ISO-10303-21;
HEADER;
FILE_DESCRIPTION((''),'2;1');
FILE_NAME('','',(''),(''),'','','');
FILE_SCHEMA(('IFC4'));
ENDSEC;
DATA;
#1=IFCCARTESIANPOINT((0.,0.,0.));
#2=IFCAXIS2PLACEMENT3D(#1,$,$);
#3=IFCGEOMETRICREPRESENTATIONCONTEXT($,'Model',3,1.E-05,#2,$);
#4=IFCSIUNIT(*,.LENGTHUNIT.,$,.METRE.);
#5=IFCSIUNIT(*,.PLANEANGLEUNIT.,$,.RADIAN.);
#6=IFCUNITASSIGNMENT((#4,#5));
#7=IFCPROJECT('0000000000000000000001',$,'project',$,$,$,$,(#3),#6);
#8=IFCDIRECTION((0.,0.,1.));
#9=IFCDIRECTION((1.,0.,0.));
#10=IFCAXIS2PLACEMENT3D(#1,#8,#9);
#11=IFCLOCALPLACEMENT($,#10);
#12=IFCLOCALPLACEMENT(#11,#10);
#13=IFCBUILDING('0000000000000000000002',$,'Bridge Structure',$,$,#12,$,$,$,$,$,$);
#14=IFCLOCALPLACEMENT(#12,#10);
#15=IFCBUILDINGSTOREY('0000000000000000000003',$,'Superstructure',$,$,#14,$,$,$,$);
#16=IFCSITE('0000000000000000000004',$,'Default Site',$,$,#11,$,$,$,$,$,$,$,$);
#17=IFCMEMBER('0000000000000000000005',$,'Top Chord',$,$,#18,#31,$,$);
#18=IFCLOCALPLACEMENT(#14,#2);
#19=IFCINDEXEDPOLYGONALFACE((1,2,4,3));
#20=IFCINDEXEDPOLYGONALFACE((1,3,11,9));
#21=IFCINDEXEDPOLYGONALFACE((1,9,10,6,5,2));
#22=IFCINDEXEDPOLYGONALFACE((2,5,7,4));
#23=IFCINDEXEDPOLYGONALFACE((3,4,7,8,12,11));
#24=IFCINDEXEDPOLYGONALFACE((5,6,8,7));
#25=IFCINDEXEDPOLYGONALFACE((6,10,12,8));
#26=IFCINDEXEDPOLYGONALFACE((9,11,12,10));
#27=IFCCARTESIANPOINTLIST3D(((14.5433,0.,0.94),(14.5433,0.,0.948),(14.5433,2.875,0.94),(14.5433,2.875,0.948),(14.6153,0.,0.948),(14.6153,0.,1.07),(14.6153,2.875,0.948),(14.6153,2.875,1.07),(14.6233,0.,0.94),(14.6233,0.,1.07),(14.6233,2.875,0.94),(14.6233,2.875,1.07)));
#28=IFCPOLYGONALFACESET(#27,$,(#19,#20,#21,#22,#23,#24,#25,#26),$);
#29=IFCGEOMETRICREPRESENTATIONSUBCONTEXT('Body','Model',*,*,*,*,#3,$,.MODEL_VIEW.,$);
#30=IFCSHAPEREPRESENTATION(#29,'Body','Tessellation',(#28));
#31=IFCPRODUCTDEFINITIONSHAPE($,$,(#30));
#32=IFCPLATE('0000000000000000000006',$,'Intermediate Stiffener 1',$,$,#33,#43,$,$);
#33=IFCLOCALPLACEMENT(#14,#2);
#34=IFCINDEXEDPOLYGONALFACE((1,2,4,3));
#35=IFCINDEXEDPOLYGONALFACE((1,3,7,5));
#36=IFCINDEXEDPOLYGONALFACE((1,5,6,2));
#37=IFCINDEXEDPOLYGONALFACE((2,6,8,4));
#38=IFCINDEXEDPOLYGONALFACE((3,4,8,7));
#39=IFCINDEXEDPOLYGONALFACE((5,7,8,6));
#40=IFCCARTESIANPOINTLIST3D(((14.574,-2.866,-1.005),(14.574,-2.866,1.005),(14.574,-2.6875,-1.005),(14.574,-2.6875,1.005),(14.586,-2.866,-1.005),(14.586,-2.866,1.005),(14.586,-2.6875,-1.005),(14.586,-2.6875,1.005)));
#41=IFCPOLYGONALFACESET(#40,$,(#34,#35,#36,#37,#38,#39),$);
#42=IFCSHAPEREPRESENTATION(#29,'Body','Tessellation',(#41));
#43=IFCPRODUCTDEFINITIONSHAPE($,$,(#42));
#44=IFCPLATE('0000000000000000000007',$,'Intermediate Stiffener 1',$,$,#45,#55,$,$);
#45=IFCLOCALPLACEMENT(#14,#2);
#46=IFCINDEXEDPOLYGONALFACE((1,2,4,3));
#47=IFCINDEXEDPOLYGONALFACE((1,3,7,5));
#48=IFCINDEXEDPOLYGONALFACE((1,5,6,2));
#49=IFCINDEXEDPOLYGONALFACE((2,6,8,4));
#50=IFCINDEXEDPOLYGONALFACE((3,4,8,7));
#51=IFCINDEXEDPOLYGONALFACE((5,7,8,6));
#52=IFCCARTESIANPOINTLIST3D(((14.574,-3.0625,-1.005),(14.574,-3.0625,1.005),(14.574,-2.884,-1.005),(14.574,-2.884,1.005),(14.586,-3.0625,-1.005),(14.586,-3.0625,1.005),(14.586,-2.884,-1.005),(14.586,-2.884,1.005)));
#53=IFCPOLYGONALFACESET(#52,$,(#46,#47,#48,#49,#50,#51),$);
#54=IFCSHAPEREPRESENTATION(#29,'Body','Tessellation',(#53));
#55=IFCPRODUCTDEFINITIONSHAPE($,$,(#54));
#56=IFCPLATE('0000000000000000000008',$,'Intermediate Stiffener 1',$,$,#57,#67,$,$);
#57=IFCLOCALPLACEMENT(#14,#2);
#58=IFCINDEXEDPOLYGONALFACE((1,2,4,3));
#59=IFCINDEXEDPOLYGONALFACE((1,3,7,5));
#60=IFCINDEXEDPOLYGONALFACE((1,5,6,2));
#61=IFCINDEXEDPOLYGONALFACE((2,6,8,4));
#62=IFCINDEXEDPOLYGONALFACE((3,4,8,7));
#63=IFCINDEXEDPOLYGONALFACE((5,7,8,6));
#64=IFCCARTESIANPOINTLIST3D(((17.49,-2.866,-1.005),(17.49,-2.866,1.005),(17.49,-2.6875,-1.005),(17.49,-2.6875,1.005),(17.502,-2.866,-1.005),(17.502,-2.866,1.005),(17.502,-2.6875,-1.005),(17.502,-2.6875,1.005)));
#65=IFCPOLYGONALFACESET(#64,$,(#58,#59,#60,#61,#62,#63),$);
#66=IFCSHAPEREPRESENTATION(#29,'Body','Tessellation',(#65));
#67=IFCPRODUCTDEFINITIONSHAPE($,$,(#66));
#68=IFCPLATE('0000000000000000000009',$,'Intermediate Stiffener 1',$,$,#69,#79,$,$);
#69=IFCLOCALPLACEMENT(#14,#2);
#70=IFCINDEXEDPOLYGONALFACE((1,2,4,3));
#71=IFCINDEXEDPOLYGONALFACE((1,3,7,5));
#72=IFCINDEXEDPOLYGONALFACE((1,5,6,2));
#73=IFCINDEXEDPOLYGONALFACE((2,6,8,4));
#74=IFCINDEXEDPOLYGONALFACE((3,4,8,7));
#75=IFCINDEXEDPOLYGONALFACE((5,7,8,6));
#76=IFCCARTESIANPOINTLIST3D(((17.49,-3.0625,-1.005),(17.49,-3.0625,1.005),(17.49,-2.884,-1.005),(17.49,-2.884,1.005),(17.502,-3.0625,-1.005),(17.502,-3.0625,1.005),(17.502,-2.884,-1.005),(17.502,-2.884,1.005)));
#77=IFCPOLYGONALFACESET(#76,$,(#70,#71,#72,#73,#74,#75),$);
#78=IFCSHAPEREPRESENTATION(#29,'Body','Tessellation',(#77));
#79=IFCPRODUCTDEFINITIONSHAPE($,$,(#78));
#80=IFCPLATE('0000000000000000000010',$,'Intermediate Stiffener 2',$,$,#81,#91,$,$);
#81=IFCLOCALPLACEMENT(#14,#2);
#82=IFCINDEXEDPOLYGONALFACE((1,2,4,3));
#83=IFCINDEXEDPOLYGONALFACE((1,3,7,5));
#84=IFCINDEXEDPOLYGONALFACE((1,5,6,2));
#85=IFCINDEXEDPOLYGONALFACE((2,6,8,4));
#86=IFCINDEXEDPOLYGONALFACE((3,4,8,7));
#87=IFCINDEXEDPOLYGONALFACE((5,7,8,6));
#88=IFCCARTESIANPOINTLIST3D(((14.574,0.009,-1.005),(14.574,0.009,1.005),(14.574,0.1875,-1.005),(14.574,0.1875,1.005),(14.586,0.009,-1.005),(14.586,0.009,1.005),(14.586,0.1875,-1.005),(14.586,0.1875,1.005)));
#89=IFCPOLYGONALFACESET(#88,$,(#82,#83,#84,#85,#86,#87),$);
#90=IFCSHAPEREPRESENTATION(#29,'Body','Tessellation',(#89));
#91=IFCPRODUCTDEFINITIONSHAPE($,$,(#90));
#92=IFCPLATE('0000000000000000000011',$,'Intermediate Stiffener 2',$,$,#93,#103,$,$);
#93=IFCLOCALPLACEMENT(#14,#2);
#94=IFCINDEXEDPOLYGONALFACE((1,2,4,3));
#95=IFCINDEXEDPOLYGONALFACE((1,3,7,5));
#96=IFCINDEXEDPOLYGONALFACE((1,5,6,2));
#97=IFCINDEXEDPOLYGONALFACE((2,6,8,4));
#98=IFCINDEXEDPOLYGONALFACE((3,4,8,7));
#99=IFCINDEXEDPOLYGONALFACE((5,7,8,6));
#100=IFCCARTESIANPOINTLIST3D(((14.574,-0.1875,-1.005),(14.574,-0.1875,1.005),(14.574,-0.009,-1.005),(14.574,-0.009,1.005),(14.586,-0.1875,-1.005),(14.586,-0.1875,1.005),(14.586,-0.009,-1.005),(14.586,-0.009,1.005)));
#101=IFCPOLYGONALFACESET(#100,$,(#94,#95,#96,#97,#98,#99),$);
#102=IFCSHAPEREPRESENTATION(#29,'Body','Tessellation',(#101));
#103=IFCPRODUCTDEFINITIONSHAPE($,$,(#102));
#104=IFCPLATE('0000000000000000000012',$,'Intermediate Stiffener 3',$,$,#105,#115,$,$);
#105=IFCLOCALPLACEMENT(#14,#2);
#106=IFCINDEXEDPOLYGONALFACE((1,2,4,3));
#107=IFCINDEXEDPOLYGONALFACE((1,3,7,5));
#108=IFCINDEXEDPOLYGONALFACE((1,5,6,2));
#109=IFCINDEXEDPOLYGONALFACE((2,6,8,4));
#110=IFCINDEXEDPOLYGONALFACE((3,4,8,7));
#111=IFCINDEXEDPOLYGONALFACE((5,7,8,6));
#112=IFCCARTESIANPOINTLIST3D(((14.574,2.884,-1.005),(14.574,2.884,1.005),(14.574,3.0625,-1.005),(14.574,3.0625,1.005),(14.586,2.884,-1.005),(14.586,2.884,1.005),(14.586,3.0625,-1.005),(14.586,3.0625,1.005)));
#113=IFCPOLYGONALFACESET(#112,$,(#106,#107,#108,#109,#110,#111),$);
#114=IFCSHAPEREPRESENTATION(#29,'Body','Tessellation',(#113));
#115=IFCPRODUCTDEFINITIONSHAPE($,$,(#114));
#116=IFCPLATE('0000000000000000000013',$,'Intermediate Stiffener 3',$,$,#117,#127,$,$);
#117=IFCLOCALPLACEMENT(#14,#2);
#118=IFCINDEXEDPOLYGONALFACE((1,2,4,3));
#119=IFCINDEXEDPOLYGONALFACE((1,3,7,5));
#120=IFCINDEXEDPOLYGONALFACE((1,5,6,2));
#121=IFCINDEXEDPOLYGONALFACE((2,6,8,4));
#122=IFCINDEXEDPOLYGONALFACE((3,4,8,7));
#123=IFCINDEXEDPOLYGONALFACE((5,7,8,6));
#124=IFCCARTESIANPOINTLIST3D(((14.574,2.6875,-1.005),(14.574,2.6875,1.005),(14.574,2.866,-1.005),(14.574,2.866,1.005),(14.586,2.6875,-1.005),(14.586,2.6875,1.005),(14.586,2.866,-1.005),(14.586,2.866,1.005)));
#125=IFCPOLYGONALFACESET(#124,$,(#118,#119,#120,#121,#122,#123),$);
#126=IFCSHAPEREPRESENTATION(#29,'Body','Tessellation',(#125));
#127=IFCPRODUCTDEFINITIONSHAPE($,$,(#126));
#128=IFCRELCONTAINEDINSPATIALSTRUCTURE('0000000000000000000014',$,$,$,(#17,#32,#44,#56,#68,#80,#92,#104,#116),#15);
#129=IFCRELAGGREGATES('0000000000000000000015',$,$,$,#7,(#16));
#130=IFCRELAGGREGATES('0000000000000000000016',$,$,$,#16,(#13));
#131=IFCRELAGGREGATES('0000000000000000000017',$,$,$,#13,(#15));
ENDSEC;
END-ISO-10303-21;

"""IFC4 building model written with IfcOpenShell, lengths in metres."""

from ifc_helpers import new_model, si_unit, frame, origin, origin_with_axes, origin_2d_with_axis, place, context, subcontext, project, spatial, rectangle, l_section, extrude, element, save


model = new_model("IFC4")

# Units and contexts
model_context = context("Model", 3, precision=1e-05, world=origin())
body_context = subcontext(model_context, "Body", "Model", "MODEL_VIEW")
ifc_project = project(units=[si_unit("LENGTHUNIT", "METRE"), si_unit("PLANEANGLEUNIT", "RADIAN")], contexts=[model_context])

# Site, building, storey
site_placement = place(None, origin_with_axes())
site = spatial("IfcSite", under=ifc_project, at=site_placement, Name="Default Site")
building_placement = place(site_placement, origin_with_axes())
building = spatial("IfcBuilding", under=site, at=building_placement, Name="Bridge Structure")
storey_placement = place(building_placement, origin_with_axes())
storey = spatial("IfcBuildingStorey", under=building, at=storey_placement, Name="Superstructure")

# Member
for number, where, z_axis, x_axis, name in (
    (1, (14.5833, 0.0, 1.005), (0.0, 1.0, 0.0), (-1.0, 0.0, 0.0), "Top Chord"),
):
    element("IfcMember", number, at=place(storey_placement, frame(where, z_axis=z_axis, x_axis=x_axis)), inside=storey, Name=name, context=body_context, shape_type="SweptSolid", body=[
        extrude(l_section(Depth=0.13, Width=0.08, Thickness=0.008, at=origin_2d_with_axis()), origin_with_axes(), (0.0, 0.0, 1.0), 2.875),
    ])

# Plates
for number, where, z_axis, x_axis, name in (
    (2, (14.58, -2.7768, -1.005), (0.0, 0.0, 1.0), (1.0, 0.0, 0.0), "Intermediate Stiffener 1"),
    (3, (14.58, -2.9733, -1.005), (0.0, 0.0, 1.0), (1.0, 0.0, 0.0), "Intermediate Stiffener 1"),
    (4, (17.496, -2.7768, -1.005), (0.0, 0.0, 1.0), (1.0, 0.0, 0.0), "Intermediate Stiffener 1"),
    (5, (17.496, -2.9733, -1.005), (0.0, 0.0, 1.0), (1.0, 0.0, 0.0), "Intermediate Stiffener 1"),
    (6, (14.58, 0.0983, -1.005), (0.0, 0.0, 1.0), (1.0, 0.0, 0.0), "Intermediate Stiffener 2"),
    (7, (14.58, -0.0983, -1.005), (0.0, 0.0, 1.0), (1.0, 0.0, 0.0), "Intermediate Stiffener 2"),
    (8, (14.58, 2.9733, -1.005), (0.0, 0.0, 1.0), (1.0, 0.0, 0.0), "Intermediate Stiffener 3"),
    (9, (14.58, 2.7768, -1.005), (0.0, 0.0, 1.0), (1.0, 0.0, 0.0), "Intermediate Stiffener 3"),
):
    element("IfcPlate", number, at=place(storey_placement, frame(where, z_axis=z_axis, x_axis=x_axis)), inside=storey, Name=name, context=body_context, shape_type="SweptSolid", body=[
        extrude(rectangle(XDim=0.012, YDim=0.1785, at=origin_2d_with_axis()), origin_with_axes(), (0.0, 0.0, 1.0), 2.01),
    ])

save(model, "model.ifc")
